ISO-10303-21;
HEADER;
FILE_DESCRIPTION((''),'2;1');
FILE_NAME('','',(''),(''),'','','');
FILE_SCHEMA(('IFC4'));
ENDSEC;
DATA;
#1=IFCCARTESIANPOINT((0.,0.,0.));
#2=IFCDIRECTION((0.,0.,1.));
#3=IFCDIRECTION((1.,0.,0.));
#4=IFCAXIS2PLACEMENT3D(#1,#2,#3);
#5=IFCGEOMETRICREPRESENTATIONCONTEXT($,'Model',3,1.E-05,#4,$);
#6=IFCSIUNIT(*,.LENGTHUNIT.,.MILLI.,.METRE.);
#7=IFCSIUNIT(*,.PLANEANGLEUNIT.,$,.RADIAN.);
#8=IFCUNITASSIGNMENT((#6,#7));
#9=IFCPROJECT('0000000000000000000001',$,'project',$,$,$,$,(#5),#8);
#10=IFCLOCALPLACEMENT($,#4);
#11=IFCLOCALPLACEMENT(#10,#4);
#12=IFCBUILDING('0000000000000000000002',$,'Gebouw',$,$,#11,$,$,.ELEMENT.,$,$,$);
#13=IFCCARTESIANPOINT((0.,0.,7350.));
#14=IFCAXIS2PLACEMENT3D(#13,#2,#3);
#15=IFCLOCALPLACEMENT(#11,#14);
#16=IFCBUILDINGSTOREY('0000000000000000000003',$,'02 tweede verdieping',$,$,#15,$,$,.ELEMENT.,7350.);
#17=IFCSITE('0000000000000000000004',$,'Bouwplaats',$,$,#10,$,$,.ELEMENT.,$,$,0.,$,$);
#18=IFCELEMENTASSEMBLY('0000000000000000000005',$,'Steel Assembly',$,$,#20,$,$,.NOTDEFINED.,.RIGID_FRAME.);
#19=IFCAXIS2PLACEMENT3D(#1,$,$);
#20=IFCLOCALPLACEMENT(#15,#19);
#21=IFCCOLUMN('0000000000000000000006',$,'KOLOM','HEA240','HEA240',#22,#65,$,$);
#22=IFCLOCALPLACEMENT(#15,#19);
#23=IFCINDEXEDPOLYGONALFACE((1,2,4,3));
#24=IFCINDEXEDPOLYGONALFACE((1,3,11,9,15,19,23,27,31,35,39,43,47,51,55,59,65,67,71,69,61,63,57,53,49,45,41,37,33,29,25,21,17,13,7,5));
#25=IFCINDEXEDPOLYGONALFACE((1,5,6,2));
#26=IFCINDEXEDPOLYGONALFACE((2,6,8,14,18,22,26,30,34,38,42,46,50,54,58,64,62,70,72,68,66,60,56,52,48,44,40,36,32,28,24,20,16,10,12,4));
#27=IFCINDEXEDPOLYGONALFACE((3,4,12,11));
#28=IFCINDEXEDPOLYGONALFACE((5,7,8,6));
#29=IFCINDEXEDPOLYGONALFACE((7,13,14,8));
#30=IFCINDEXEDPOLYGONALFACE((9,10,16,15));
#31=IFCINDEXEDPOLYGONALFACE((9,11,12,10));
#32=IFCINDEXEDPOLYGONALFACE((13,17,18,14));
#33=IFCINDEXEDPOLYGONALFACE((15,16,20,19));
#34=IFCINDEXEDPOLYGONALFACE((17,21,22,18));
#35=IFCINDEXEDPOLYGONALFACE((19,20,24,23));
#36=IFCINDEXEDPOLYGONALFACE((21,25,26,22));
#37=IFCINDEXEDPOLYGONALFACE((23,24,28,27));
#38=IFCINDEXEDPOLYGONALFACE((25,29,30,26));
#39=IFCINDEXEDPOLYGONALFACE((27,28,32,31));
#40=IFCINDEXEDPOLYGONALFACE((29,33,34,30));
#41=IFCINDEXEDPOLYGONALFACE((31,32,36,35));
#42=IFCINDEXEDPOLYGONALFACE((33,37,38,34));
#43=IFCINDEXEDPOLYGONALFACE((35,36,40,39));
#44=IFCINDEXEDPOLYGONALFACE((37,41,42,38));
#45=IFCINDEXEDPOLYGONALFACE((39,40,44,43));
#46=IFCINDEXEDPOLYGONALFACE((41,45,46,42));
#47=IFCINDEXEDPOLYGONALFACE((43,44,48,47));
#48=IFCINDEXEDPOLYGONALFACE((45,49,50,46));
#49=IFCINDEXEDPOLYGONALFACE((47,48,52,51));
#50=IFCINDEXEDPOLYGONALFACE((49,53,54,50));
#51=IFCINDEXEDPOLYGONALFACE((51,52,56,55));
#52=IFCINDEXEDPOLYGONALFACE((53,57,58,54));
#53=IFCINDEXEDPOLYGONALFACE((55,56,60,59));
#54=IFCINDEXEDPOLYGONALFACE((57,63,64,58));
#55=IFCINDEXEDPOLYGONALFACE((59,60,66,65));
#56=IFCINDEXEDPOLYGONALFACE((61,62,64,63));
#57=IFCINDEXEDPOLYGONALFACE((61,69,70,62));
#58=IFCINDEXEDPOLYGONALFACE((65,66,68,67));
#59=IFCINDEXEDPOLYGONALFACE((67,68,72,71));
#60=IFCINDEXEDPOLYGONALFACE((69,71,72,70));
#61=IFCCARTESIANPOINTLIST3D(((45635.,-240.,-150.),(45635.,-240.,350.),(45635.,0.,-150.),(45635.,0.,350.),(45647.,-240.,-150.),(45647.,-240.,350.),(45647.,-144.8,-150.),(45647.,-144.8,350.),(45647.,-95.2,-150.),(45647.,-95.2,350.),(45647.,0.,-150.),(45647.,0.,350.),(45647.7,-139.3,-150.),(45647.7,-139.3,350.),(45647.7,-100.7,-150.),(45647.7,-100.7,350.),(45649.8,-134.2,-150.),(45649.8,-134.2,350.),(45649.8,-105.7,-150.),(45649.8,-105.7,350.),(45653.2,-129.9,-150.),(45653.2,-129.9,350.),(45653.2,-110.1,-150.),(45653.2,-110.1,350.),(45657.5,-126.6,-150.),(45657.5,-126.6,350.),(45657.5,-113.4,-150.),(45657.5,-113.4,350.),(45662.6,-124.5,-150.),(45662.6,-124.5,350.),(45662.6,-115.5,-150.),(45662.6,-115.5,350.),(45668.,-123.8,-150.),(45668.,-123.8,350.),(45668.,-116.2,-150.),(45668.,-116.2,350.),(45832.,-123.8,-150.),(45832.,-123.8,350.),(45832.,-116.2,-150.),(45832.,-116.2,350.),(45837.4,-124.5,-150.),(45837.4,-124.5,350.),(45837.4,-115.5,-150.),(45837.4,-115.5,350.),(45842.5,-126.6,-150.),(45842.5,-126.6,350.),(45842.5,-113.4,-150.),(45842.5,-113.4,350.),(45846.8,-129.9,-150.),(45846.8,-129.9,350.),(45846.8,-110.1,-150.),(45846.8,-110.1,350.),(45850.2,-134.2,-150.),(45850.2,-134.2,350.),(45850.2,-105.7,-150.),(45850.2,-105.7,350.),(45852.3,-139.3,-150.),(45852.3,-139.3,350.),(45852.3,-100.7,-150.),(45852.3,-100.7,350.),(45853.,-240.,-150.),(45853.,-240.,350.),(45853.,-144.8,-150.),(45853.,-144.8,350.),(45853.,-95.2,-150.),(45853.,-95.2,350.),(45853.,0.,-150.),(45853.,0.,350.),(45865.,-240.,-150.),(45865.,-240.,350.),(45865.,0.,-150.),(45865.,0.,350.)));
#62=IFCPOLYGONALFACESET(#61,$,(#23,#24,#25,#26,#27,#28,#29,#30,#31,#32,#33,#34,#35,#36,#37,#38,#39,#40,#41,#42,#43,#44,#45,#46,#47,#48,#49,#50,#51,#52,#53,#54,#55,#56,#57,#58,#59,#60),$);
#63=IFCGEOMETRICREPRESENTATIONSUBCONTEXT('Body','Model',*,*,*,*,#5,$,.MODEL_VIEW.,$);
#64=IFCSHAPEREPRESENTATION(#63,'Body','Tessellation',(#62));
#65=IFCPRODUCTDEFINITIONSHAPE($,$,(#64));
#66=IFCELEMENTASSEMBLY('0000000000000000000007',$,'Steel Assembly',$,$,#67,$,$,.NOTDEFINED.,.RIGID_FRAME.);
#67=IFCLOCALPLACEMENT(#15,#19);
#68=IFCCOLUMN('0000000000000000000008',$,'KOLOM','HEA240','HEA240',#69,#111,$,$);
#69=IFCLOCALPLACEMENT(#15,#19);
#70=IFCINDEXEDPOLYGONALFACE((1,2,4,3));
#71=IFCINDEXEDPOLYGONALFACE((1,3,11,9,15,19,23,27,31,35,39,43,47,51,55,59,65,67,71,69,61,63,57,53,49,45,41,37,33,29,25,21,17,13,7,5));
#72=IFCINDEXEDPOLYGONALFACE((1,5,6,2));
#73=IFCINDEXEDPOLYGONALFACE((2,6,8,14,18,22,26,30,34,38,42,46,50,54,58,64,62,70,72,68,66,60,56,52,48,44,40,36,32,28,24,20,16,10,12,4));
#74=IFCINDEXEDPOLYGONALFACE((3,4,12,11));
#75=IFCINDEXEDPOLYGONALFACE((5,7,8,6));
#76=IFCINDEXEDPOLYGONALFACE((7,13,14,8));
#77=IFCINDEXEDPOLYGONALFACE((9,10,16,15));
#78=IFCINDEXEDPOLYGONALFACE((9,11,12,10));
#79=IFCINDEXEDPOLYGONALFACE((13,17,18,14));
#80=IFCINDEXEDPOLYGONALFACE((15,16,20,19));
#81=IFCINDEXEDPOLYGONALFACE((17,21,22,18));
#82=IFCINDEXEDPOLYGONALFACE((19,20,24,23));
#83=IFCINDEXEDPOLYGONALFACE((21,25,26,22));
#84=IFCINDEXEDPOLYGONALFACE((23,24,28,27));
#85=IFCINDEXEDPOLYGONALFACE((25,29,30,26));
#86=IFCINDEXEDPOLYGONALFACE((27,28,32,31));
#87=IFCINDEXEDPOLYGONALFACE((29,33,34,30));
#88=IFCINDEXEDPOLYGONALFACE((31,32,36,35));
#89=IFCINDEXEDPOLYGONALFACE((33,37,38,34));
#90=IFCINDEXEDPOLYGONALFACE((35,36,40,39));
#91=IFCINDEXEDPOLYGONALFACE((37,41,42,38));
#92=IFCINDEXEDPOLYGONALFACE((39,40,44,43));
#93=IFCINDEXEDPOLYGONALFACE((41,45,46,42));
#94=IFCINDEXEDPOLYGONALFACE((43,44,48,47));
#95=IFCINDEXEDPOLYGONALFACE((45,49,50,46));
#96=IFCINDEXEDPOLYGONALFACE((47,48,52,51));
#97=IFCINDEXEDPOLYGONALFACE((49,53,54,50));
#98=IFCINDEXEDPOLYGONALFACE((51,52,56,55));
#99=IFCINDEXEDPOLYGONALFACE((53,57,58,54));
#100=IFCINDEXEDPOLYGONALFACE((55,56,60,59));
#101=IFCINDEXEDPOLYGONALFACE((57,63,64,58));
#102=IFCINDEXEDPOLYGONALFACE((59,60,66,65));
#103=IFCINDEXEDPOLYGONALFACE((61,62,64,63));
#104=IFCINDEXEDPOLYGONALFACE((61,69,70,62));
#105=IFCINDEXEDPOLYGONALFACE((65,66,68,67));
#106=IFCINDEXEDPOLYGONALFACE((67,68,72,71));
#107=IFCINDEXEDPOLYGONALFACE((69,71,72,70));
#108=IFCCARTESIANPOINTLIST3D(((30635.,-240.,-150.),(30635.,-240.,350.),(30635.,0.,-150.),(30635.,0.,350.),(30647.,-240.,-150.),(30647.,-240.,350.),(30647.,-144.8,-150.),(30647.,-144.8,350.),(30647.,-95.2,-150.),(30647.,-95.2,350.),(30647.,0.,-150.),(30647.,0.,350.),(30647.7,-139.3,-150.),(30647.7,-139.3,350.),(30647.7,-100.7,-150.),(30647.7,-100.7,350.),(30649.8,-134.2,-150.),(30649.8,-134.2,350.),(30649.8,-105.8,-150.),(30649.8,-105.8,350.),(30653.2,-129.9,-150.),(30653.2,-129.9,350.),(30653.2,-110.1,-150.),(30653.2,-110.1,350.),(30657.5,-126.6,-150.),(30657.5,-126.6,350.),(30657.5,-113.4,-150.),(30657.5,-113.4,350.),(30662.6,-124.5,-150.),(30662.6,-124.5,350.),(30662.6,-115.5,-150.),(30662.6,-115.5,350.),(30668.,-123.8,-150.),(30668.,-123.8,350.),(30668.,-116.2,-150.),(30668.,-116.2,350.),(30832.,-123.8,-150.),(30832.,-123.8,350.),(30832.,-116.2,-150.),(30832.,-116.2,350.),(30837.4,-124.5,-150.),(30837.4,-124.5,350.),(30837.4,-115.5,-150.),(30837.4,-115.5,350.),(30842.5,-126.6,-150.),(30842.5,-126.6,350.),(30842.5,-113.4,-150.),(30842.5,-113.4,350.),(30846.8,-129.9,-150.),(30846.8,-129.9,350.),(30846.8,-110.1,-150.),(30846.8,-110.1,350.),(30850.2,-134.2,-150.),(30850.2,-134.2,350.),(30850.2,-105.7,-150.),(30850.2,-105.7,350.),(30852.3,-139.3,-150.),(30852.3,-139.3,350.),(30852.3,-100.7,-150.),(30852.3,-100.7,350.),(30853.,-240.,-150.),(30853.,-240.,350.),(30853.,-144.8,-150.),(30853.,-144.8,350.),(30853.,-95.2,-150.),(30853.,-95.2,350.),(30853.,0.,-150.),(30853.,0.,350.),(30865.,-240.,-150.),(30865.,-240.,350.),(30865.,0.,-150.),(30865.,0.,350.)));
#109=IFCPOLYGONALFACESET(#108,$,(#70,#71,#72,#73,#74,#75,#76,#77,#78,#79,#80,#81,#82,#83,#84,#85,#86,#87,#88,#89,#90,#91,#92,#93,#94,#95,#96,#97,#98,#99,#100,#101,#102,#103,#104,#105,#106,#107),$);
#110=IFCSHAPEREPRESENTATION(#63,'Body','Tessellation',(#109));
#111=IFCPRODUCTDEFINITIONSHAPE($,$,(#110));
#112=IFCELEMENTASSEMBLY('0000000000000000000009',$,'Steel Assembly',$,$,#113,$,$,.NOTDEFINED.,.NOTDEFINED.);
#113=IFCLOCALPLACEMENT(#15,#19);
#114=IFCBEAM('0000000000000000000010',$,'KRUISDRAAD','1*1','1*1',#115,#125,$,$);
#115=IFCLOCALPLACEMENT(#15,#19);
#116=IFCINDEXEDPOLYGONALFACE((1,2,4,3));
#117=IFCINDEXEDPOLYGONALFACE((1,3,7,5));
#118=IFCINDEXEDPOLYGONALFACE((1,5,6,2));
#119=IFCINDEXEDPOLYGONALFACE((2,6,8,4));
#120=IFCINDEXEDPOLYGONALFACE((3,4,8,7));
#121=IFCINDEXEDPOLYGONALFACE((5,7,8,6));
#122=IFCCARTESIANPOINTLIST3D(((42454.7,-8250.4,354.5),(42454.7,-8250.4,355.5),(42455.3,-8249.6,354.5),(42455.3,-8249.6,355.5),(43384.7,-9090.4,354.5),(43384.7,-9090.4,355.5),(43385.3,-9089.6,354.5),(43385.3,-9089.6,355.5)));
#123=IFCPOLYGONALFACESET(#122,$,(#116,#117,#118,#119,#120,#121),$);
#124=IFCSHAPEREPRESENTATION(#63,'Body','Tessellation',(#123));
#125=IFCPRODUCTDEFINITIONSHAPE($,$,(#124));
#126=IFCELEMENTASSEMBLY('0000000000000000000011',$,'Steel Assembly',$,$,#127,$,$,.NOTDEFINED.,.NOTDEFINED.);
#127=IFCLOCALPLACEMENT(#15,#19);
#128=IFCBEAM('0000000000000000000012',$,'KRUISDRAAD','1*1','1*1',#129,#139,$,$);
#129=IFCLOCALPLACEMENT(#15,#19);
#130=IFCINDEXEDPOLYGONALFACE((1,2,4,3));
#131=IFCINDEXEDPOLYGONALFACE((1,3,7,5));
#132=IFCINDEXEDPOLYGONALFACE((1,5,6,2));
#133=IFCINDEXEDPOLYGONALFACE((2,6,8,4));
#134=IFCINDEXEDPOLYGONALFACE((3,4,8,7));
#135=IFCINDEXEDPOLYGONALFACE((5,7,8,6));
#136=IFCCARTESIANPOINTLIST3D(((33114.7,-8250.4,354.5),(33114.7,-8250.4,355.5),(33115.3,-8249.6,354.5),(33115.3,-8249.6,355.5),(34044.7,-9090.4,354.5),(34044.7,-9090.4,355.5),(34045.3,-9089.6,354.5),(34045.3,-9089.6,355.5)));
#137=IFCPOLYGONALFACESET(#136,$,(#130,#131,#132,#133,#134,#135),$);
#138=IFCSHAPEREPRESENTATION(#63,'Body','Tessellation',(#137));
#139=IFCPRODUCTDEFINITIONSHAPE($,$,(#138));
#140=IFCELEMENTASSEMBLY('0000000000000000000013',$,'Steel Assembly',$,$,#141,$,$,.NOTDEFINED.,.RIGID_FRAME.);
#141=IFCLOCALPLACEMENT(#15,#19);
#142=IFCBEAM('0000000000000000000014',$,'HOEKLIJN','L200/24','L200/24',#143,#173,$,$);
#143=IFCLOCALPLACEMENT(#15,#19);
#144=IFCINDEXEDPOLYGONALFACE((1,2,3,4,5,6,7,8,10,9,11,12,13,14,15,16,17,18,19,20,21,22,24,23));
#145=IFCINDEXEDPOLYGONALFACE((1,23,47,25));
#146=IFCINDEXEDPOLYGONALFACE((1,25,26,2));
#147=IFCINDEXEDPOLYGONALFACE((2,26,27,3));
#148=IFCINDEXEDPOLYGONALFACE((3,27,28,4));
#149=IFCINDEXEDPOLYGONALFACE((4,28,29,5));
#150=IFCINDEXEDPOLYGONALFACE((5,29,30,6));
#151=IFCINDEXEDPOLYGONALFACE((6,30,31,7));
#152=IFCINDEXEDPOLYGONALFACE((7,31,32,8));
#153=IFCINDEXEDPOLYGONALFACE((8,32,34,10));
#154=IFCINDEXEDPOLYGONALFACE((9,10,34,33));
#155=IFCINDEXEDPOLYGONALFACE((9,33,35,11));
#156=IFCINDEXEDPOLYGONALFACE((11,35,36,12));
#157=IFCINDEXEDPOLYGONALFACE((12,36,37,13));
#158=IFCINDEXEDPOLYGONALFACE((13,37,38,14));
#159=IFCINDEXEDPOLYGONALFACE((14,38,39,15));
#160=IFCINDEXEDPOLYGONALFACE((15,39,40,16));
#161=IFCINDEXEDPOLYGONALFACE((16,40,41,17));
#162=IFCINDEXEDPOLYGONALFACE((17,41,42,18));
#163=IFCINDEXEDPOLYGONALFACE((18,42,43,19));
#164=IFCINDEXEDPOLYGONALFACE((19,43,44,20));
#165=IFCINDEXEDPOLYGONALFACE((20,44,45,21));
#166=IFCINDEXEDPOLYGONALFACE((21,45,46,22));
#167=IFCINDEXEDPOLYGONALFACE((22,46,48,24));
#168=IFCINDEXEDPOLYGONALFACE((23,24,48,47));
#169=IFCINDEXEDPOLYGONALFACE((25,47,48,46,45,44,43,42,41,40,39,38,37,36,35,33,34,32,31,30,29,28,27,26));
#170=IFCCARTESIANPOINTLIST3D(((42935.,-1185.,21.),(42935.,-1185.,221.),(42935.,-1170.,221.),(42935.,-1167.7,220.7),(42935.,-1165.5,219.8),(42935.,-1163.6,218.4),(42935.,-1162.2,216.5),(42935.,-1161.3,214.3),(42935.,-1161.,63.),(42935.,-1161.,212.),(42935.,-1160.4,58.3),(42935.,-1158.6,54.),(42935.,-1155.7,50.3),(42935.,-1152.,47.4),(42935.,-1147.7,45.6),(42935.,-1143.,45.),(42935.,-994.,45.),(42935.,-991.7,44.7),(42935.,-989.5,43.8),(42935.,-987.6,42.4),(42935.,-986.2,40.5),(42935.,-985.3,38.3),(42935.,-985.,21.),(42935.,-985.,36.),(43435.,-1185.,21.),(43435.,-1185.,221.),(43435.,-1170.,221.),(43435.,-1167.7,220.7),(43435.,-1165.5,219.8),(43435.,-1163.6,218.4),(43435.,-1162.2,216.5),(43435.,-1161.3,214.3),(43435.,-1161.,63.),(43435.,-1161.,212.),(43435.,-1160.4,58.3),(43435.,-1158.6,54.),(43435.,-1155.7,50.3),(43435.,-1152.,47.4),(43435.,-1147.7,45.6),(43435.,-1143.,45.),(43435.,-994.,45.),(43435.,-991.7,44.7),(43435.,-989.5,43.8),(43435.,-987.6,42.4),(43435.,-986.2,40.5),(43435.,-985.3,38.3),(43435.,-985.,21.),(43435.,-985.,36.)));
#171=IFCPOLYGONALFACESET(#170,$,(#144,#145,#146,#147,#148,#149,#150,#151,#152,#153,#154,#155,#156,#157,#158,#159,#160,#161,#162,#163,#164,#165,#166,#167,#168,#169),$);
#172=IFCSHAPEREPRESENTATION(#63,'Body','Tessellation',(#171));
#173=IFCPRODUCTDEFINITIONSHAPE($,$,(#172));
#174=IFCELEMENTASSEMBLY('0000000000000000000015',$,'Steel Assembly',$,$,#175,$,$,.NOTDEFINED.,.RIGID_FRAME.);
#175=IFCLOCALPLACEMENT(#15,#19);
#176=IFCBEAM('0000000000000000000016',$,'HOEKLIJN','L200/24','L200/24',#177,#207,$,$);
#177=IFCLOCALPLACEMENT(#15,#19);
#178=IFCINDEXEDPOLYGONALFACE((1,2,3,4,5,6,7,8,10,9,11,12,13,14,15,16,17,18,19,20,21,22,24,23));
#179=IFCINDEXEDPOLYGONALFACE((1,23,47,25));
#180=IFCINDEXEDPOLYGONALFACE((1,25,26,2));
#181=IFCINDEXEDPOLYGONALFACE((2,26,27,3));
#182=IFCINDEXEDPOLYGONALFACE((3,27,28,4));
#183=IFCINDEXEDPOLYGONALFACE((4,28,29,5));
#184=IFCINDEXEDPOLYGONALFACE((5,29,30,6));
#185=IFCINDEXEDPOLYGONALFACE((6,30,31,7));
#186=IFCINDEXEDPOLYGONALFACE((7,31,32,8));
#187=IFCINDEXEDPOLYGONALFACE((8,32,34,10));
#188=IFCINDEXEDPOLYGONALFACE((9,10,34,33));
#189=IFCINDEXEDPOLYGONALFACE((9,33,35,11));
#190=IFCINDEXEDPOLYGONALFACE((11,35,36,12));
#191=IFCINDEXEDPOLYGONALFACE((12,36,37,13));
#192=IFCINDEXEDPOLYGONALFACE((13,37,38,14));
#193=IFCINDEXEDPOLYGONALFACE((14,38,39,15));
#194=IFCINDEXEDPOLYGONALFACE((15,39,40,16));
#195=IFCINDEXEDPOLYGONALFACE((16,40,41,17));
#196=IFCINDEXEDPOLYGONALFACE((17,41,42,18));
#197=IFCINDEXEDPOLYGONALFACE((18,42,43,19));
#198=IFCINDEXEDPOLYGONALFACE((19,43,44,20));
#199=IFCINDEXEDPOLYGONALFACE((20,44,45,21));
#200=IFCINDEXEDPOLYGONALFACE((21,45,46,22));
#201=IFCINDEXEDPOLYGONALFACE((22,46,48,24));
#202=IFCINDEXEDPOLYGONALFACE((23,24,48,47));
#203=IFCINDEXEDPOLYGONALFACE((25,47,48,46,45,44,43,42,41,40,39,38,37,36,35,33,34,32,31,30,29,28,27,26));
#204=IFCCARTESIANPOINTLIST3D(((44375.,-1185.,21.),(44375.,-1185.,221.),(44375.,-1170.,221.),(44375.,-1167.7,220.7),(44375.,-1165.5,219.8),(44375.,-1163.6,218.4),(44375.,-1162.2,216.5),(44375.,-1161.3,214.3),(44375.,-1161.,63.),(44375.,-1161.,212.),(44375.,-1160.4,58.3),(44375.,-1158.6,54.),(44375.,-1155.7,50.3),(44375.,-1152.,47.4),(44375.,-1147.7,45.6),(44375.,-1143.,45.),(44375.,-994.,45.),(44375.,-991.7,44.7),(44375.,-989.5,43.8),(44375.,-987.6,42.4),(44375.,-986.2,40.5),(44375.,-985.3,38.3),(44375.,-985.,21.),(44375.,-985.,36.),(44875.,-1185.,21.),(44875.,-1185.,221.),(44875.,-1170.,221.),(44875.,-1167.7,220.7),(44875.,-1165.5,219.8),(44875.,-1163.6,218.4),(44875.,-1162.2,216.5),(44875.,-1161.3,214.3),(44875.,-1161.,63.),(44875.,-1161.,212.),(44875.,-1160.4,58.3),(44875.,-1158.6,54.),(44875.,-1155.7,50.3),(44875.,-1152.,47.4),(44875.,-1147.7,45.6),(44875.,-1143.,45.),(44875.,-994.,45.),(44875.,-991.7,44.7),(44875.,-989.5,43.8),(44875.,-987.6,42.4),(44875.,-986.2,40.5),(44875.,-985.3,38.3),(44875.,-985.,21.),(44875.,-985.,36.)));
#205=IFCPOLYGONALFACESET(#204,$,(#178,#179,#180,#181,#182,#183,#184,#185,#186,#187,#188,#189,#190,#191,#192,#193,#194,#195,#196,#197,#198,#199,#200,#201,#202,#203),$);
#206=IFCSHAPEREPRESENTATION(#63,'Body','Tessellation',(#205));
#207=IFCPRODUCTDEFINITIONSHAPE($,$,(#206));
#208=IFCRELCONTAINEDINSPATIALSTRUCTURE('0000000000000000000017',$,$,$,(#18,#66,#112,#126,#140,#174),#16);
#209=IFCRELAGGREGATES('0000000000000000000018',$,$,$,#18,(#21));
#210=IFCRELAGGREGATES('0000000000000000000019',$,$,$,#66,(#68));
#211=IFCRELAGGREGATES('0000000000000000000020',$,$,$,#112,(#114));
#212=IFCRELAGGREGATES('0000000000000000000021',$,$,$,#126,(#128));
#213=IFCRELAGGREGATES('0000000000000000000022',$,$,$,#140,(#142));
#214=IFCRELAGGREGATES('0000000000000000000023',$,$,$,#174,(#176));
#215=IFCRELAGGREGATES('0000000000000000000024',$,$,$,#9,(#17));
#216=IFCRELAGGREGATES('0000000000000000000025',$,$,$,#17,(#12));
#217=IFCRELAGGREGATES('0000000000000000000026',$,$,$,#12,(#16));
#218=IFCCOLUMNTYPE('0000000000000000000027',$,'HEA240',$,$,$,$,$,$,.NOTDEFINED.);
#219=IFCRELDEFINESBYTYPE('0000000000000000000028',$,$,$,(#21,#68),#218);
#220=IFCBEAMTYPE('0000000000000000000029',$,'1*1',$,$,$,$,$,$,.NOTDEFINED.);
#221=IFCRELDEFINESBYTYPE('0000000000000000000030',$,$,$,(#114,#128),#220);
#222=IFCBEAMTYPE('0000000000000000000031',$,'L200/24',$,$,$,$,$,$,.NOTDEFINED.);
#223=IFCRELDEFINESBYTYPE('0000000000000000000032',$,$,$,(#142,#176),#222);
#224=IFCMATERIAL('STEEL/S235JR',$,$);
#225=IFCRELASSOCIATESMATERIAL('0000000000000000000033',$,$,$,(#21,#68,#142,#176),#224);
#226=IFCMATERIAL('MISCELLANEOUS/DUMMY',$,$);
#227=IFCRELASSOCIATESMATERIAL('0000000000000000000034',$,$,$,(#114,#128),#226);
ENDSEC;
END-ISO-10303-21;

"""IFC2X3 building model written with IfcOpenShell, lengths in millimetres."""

from ifc_helpers import new_model, si_unit, frame, origin_with_axes, origin_2d_with_axis, place, context, subcontext, project, spatial, rectangle, i_section, l_section, extrude, material, type_object, element, aggregate, save


model = new_model("IFC2X3")

# Units and contexts
model_context = context("Model", 3, precision=1e-05, world=origin_with_axes())
body_context = subcontext(model_context, "Body", "Model", "MODEL_VIEW")
ifc_project = project(units=[si_unit("LENGTHUNIT", "METRE", prefix="MILLI"), si_unit("PLANEANGLEUNIT", "RADIAN")], contexts=[model_context])

# Site, building, storey
site_placement = place(None, origin_with_axes())
site = spatial("IfcSite", under=ifc_project, at=site_placement, Name="Bouwplaats", CompositionType="ELEMENT", RefElevation=0.0)
building_placement = place(site_placement, origin_with_axes())
building = spatial("IfcBuilding", under=site, at=building_placement, Name="Gebouw", CompositionType="ELEMENT")
storey_placement = place(building_placement, frame((0.0, 0.0, 7350.0), z_axis=(0.0, 0.0, 1.0), x_axis=(1.0, 0.0, 0.0)))
storey = spatial("IfcBuildingStorey", under=building, at=storey_placement, Name="02 tweede verdieping", CompositionType="ELEMENT", Elevation=7350.0)

# Element assemblies, columns
assembly_1_placement = place(storey_placement, origin_with_axes())
assembly_1 = element("IfcElementAssembly", 1, at=assembly_1_placement, inside=storey, Name="Steel Assembly", AssemblyPlace="NOTDEFINED", PredefinedType="RIGID_FRAME")
ifc_material_1 = material(Name="STEEL/S235JR")
column_type = type_object("IfcColumnType", Name="HEA240", PredefinedType="NOTDEFINED")
column_1_placement = place(assembly_1_placement, frame((45750.0, -120.0, -150.0), z_axis=(0.0, 0.0, 1.0), x_axis=(1.0, 0.0, 0.0)))
column_1 = element("IfcColumn", 2, at=column_1_placement, type_object=column_type, material=ifc_material_1, Name="KOLOM", Description="HEA240", ObjectType="HEA240", context=body_context, shape_type="SweptSolid", body=[
    extrude(i_section(OverallWidth=240.0, OverallDepth=230.0, WebThickness=7.5, FlangeThickness=12.0, FilletRadius=21.0, at=origin_2d_with_axis()), frame((0.0, 0.0, 500.0), z_axis=(0.0, 0.0, -1.0), x_axis=(0.0, 1.0, 0.0)), (0.0, 0.0, 1.0), 500.0),
])
aggregate(assembly_1, [column_1])
assembly_2_placement = place(storey_placement, origin_with_axes())
assembly_2 = element("IfcElementAssembly", 3, at=assembly_2_placement, inside=storey, Name="Steel Assembly", AssemblyPlace="NOTDEFINED", PredefinedType="RIGID_FRAME")
column_2_placement = place(assembly_2_placement, frame((30750.0, -120.0, -150.0), z_axis=(0.0, 0.0, 1.0), x_axis=(-1.0, 0.0, 0.0)))
column_2 = element("IfcColumn", 4, at=column_2_placement, type_object=column_type, material=ifc_material_1, Name="KOLOM", Description="HEA240", ObjectType="HEA240", context=body_context, shape_type="SweptSolid", body=[
    extrude(i_section(OverallWidth=240.0, OverallDepth=230.0, WebThickness=7.5, FlangeThickness=12.0, FilletRadius=21.0, at=origin_2d_with_axis()), frame((0.0, 0.0, 500.0), z_axis=(0.0, 0.0, -1.0), x_axis=(0.0, 1.0, 0.0)), (0.0, 0.0, 1.0), 500.0),
])
aggregate(assembly_2, [column_2])

# Element assemblies, beams
assembly_3_placement = place(storey_placement, origin_with_axes())
assembly_3 = element("IfcElementAssembly", 5, at=assembly_3_placement, inside=storey, Name="Steel Assembly", AssemblyPlace="NOTDEFINED", PredefinedType="NOTDEFINED")
ifc_material_2 = material(Name="MISCELLANEOUS/DUMMY")
beam_type_1 = type_object("IfcBeamType", Name="1*1", PredefinedType="NOTDEFINED")
beam_1_placement = place(assembly_3_placement, frame((42455.0, -8250.0, 355.0), z_axis=(0.0, 0.0, 1.0), x_axis=(0.7421, -0.670289, 0.0)))
beam_1 = element("IfcBeam", 6, at=beam_1_placement, type_object=beam_type_1, material=ifc_material_2, Name="KRUISDRAAD", Description="1*1", ObjectType="1*1", context=body_context, shape_type="SweptSolid", body=[
    extrude(rectangle(XDim=1.0, YDim=1.0, at=origin_2d_with_axis()), frame((1253.2, 0.0, 0.0), z_axis=(-1.0, 0.0, 0.0), x_axis=(0.0, -1.0, 0.0)), (0.0, 0.0, 1.0), 1253.2),
])
aggregate(assembly_3, [beam_1])
assembly_4_placement = place(storey_placement, origin_with_axes())
assembly_4 = element("IfcElementAssembly", 7, at=assembly_4_placement, inside=storey, Name="Steel Assembly", AssemblyPlace="NOTDEFINED", PredefinedType="NOTDEFINED")
beam_2_placement = place(assembly_4_placement, frame((33115.0, -8250.0, 355.0), z_axis=(0.0, 0.0, 1.0), x_axis=(0.7421, -0.670289, 0.0)))
beam_2 = element("IfcBeam", 8, at=beam_2_placement, type_object=beam_type_1, material=ifc_material_2, Name="KRUISDRAAD", Description="1*1", ObjectType="1*1", context=body_context, shape_type="SweptSolid", body=[
    extrude(rectangle(XDim=1.0, YDim=1.0, at=origin_2d_with_axis()), frame((1253.2, 0.0, 0.0), z_axis=(-1.0, 0.0, 0.0), x_axis=(0.0, -1.0, 0.0)), (0.0, 0.0, 1.0), 1253.2),
])
aggregate(assembly_4, [beam_2])
assembly_5_placement = place(storey_placement, origin_with_axes())
assembly_5 = element("IfcElementAssembly", 9, at=assembly_5_placement, inside=storey, Name="Steel Assembly", AssemblyPlace="NOTDEFINED", PredefinedType="RIGID_FRAME")
beam_type_2 = type_object("IfcBeamType", Name="L200/24", PredefinedType="NOTDEFINED")
beam_3_placement = place(assembly_5_placement, frame((42935.0, -1085.0, 121.0), z_axis=(0.0, 1.0, 0.0), x_axis=(1.0, 0.0, 0.0)))
beam_3 = element("IfcBeam", 10, at=beam_3_placement, type_object=beam_type_2, material=ifc_material_1, Name="HOEKLIJN", Description="L200/24", ObjectType="L200/24", context=body_context, shape_type="SweptSolid", body=[
    extrude(l_section(Depth=200.0, Width=200.0, Thickness=24.0, FilletRadius=18.0, EdgeRadius=9.0, at=origin_2d_with_axis()), frame((500.0, 0.0, 0.0), z_axis=(-1.0, 0.0, 0.0), x_axis=(0.0, -1.0, 0.0)), (0.0, 0.0, 1.0), 500.0),
])
aggregate(assembly_5, [beam_3])
assembly_6_placement = place(storey_placement, origin_with_axes())
assembly_6 = element("IfcElementAssembly", 11, at=assembly_6_placement, inside=storey, Name="Steel Assembly", AssemblyPlace="NOTDEFINED", PredefinedType="RIGID_FRAME")
beam_4_placement = place(assembly_6_placement, frame((44375.0, -1085.0, 121.0), z_axis=(0.0, 1.0, 0.0), x_axis=(1.0, 0.0, 0.0)))
beam_4 = element("IfcBeam", 12, at=beam_4_placement, type_object=beam_type_2, material=ifc_material_1, Name="HOEKLIJN", Description="L200/24", ObjectType="L200/24", context=body_context, shape_type="SweptSolid", body=[
    extrude(l_section(Depth=200.0, Width=200.0, Thickness=24.0, FilletRadius=18.0, EdgeRadius=9.0, at=origin_2d_with_axis()), frame((500.0, 0.0, 0.0), z_axis=(-1.0, 0.0, 0.0), x_axis=(0.0, -1.0, 0.0)), (0.0, 0.0, 1.0), 500.0),
])
aggregate(assembly_6, [beam_4])

save(model, "model.ifc")
